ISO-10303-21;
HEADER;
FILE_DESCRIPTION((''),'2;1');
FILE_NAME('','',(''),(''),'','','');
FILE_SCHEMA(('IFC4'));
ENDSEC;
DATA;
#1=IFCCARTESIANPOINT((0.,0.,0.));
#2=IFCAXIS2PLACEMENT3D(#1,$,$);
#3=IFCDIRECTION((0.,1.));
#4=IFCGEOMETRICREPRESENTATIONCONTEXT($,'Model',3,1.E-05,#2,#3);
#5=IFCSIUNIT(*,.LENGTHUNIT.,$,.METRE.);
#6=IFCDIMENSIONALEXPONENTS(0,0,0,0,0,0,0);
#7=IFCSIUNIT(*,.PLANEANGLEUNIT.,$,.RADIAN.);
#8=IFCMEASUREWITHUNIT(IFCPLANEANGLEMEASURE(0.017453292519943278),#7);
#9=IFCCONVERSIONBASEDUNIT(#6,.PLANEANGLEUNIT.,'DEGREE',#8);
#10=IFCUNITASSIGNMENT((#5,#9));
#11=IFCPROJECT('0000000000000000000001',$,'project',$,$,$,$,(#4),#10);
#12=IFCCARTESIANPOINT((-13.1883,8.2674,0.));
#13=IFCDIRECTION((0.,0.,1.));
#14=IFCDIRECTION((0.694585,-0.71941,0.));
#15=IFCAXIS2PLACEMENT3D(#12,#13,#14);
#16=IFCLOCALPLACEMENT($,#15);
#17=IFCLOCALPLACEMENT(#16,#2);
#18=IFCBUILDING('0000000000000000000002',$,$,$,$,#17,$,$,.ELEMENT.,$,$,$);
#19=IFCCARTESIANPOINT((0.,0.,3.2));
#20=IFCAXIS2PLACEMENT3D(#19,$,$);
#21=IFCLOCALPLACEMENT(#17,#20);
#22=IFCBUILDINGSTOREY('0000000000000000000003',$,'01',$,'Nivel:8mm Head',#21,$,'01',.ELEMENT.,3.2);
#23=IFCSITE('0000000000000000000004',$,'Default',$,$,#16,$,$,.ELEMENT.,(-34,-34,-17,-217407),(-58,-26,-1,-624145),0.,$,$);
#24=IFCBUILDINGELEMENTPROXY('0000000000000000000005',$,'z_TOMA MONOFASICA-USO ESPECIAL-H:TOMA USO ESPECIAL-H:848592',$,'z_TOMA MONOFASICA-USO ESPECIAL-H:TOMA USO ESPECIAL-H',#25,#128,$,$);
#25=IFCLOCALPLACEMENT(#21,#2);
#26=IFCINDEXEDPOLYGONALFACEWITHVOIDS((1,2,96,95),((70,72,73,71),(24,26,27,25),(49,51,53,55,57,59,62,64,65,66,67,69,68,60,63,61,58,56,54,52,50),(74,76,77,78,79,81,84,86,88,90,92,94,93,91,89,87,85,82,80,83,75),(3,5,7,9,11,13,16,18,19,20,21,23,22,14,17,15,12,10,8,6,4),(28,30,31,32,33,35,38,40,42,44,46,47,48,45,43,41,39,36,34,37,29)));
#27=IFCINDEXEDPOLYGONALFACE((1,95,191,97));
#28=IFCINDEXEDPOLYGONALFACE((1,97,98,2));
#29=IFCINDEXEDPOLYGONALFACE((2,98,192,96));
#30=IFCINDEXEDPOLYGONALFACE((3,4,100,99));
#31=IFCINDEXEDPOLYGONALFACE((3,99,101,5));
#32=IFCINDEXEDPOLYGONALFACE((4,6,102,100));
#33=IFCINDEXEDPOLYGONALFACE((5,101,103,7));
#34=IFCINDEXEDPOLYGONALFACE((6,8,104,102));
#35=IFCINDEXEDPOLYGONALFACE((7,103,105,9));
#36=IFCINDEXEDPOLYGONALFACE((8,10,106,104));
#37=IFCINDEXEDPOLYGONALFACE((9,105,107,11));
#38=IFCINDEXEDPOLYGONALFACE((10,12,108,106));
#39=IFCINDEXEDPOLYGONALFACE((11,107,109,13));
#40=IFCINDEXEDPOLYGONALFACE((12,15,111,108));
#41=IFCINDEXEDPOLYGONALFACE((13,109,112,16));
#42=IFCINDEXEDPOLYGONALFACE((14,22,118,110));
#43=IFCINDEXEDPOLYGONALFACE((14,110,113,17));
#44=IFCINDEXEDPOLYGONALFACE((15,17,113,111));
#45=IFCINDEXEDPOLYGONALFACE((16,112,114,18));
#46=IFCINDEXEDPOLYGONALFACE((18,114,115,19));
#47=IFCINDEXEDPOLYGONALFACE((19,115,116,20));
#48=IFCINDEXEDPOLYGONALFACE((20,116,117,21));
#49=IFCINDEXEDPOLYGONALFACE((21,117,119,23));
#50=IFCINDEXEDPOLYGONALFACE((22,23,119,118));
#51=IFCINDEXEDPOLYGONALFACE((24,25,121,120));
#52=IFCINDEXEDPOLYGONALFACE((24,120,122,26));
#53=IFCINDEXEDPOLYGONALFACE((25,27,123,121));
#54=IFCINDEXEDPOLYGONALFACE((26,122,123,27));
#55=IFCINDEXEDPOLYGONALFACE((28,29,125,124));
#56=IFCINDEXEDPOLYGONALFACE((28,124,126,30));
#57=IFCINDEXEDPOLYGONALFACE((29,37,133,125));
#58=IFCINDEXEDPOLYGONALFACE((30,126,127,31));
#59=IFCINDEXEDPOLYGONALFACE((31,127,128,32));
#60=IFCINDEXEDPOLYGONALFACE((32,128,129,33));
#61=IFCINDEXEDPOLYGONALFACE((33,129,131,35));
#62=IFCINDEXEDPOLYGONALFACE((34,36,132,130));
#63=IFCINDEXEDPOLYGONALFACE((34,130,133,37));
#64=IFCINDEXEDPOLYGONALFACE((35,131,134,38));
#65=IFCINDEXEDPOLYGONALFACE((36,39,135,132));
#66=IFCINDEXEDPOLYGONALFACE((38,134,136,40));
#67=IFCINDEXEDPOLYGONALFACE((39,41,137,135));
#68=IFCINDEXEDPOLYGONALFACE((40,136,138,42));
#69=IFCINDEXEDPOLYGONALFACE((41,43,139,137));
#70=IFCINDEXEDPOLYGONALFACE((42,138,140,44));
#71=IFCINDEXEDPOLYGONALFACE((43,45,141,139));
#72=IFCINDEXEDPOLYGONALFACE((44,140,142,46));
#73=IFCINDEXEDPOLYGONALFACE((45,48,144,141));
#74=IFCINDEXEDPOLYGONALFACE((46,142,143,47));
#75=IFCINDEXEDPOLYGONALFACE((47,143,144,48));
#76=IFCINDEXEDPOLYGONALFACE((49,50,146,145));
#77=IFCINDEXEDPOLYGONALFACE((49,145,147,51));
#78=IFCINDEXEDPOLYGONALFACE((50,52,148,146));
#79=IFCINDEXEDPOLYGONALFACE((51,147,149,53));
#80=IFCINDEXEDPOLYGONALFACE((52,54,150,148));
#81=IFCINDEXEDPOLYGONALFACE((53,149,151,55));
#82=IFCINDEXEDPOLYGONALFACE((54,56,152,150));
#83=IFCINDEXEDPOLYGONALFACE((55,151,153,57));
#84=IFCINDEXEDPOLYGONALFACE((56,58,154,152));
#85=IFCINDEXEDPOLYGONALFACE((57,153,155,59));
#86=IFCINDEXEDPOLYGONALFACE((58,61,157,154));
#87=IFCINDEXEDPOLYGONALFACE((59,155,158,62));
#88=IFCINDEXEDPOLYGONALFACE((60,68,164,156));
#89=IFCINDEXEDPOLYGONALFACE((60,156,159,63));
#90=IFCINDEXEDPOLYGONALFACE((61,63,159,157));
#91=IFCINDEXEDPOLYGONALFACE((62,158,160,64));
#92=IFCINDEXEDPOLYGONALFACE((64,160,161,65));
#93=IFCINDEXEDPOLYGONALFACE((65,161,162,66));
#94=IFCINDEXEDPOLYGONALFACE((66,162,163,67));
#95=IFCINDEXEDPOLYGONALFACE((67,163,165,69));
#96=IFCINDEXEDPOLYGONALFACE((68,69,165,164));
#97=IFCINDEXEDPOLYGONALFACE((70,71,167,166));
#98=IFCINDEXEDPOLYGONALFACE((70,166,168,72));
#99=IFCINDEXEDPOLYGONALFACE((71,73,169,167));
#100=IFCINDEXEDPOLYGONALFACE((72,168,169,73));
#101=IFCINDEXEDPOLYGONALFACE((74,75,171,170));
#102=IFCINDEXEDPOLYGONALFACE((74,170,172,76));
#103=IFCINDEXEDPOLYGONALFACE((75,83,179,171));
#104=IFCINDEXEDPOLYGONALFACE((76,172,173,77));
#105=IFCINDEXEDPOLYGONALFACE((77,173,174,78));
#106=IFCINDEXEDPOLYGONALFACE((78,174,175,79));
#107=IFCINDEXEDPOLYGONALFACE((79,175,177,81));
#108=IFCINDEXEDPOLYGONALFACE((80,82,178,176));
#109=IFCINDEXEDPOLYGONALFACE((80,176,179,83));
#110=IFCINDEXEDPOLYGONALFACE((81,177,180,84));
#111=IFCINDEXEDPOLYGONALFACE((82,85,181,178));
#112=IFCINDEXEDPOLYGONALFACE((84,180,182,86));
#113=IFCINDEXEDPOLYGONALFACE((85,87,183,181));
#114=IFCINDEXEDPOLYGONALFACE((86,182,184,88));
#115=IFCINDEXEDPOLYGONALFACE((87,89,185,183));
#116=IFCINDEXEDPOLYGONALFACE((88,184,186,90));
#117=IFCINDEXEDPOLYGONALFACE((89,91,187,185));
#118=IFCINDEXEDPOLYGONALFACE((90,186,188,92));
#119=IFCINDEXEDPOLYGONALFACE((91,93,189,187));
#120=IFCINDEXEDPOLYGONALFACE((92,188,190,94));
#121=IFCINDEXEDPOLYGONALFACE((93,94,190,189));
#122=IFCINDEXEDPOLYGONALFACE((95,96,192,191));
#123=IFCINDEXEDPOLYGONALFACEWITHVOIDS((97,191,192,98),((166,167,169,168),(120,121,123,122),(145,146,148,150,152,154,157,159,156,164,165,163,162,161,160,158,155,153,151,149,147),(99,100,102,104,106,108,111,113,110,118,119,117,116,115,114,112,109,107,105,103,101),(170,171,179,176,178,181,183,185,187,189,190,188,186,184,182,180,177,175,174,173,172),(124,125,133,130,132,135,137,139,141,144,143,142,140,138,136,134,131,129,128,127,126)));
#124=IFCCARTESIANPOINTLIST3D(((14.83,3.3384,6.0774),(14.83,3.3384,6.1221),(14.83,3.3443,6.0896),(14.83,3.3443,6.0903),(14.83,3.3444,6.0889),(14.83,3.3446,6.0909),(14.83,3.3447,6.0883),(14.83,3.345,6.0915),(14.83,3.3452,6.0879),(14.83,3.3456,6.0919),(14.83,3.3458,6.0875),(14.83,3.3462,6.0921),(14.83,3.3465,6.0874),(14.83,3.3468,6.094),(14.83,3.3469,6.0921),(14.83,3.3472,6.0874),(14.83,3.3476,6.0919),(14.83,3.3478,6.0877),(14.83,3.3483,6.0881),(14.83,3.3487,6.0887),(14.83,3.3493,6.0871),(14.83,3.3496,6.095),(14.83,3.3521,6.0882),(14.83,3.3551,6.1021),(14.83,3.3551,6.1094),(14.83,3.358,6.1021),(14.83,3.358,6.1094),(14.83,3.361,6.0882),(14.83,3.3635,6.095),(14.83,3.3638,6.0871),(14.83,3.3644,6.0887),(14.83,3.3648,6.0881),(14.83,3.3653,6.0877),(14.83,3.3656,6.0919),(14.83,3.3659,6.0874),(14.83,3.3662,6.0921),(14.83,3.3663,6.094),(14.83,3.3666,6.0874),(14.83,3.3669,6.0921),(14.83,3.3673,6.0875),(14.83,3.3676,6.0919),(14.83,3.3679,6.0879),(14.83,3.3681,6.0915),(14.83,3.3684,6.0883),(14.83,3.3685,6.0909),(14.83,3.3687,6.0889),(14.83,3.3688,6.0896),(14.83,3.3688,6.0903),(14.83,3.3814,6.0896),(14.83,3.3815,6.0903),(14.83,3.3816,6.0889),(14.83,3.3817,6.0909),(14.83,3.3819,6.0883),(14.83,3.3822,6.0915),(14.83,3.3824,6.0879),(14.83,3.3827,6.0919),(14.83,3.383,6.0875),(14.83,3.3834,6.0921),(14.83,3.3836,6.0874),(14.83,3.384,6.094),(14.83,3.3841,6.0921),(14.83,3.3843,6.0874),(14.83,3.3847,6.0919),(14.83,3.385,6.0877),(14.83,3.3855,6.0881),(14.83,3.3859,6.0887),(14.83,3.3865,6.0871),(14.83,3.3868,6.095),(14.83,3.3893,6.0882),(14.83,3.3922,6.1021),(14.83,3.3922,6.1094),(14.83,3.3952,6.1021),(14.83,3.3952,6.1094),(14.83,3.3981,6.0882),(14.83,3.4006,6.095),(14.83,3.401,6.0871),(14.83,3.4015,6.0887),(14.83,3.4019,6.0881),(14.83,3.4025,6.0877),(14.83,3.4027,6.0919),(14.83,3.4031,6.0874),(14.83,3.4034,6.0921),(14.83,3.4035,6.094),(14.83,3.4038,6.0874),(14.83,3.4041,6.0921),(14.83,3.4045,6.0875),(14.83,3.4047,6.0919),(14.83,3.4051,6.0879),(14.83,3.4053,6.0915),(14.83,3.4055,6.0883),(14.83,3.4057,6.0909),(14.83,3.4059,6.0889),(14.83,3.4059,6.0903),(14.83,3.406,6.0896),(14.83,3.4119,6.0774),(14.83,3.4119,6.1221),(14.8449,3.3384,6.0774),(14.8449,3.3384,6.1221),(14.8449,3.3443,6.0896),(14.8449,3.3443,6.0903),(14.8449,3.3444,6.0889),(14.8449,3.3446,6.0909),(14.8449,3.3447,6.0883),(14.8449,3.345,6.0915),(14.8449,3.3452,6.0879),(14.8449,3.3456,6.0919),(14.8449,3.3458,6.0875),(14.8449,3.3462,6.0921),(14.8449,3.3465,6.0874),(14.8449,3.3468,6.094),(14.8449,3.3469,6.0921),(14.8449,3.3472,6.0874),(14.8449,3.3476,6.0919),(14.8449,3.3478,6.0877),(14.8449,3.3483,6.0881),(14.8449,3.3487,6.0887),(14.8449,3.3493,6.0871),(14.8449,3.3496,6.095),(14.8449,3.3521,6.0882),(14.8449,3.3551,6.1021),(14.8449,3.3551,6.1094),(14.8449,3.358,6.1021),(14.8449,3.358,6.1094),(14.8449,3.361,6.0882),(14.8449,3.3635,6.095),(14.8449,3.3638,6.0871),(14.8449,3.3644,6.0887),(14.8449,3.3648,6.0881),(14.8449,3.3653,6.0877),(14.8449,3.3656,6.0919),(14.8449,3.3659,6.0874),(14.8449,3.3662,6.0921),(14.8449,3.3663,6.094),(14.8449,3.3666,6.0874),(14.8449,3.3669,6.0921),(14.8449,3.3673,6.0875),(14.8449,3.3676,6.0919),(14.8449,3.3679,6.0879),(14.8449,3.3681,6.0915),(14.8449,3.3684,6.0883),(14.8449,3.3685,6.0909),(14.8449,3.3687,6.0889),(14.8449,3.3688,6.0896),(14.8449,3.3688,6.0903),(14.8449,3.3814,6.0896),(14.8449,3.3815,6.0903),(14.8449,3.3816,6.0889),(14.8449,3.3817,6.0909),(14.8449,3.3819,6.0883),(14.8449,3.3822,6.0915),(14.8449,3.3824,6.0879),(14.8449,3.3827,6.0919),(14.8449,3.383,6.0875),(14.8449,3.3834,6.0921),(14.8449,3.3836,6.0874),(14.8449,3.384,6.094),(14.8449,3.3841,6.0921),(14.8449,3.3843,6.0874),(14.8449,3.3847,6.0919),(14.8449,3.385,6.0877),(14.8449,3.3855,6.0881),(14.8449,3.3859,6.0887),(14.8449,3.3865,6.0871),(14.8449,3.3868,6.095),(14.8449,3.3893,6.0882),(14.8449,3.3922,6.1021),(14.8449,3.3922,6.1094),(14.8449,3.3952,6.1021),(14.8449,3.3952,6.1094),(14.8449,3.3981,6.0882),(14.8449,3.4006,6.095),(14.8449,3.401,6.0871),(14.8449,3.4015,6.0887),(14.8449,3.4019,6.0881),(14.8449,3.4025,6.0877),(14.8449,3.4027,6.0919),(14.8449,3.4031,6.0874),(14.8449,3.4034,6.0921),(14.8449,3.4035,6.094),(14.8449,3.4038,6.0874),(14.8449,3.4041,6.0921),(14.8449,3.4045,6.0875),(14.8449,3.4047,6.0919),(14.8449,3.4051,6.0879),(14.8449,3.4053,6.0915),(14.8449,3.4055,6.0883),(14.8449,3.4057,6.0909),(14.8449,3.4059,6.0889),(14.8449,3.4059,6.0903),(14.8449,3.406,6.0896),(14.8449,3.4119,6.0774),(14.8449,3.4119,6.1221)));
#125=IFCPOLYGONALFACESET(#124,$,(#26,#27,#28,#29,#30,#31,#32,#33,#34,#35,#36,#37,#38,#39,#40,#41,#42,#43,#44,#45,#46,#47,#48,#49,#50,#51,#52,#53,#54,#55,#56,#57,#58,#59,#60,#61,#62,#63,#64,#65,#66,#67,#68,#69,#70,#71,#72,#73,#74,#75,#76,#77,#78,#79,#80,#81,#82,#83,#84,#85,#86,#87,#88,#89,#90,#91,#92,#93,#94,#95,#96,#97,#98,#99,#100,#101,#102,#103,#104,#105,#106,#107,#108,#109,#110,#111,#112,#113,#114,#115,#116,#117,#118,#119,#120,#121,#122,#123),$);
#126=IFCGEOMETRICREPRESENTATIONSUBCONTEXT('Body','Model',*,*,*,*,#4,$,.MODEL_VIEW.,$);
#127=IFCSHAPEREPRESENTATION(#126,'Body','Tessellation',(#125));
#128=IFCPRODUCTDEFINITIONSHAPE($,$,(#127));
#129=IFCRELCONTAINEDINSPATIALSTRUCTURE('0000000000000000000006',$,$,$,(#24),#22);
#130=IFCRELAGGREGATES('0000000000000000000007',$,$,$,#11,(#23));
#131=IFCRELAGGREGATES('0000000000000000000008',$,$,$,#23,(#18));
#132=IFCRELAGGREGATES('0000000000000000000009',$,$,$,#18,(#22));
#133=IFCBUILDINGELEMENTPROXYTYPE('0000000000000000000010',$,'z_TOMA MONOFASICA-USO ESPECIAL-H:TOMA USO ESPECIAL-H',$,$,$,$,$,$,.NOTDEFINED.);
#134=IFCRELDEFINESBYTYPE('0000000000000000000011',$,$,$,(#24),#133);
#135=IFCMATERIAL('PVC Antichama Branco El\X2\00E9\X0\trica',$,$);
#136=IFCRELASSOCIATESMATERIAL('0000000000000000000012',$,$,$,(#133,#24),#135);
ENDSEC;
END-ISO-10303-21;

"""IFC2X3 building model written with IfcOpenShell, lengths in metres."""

from ifc_helpers import new_model, entity, si_unit, converted_unit, direction, frame, frame_2d, origin, place, context, subcontext, project, spatial, polyline, circle_curve, parameter, trimmed, segment, composite_curve, outline, extrude, source, transform, mapped, material, type_object, type_shapes, element, save


model = new_model("IFC2X3")

# Units and contexts
model_context = context("Model", 3, precision=1e-05, world=origin(), true_north=direction((0.0, 1.0)))
body_context = subcontext(model_context, "Body", "Model", "MODEL_VIEW")
ifc_project = project(units=[si_unit("LENGTHUNIT", "METRE"), converted_unit("PLANEANGLEUNIT", "DEGREE", entity("IfcPlaneAngleMeasure", 0.017453292519943278), si_unit("PLANEANGLEUNIT", "RADIAN"), dimensions=[0, 0, 0, 0, 0, 0, 0])], contexts=[model_context])

# Site, building, storey
site_placement = place(None, frame((-13.1883, 8.2674, 0.0), z_axis=(0.0, 0.0, 1.0), x_axis=(0.694585, -0.71941, 0.0)))
site = spatial("IfcSite", under=ifc_project, at=site_placement, Name="Default", CompositionType="ELEMENT", RefLatitude=(-34, -34, -17, -217407), RefLongitude=(-58, -26, -1, -624145), RefElevation=0.0)
building_placement = place(site_placement, origin())
building = spatial("IfcBuilding", under=site, at=building_placement, CompositionType="ELEMENT")
storey_placement = place(building_placement, frame((0.0, 0.0, 3.2)))
storey = spatial("IfcBuildingStorey", under=building, at=storey_placement, Name="01", ObjectType="Nivel:8mm Head", LongName="01", CompositionType="ELEMENT", Elevation=3.2)

# Building element proxy
ifc_material_1 = material(Name="PVC Antichama Branco Elétrica")
building_element_proxy_type_1 = type_object("IfcBuildingElementProxyType", Name="z_TOMA MONOFASICA-USO ESPECIAL-H:TOMA USO ESPECIAL-H", PredefinedType="NOTDEFINED", material=ifc_material_1)
shared_shape_1 = source(origin(), body_context, "Body", "SweptSolid", [
    extrude(outline(polyline([(-0.0368, -0.0223), (0.0368, -0.0223), (0.0368, 0.0223), (-0.0368, 0.0223), (-0.0368, -0.0223)]), holes=[composite_curve([segment(polyline([(0.0141, 0.0115), (0.0116, 0.0047)]), True, "CONTINUOUS"), segment(polyline([(0.0116, 0.0047), (0.0088, 0.0057)]), True, "CONTINUOUS"), segment(polyline([(0.0088, 0.0057), (0.0096, 0.0078)]), True, "CONTINUOUS"), segment(trimmed(circle_curve(frame_2d((0.0087, 0.0099), x_axis=(1.0, 0.0)), 0.0024), [parameter(27.118901)], [parameter(292.881099)], True, "PARAMETER"), False, "CONTINUOUS"), segment(polyline([(0.0108, 0.011), (0.0113, 0.0126)]), True, "CONTINUOUS"), segment(polyline([(0.0113, 0.0126), (0.0141, 0.0115)]), True, "CONTINUOUS")], self_intersect=False), composite_curve([segment(polyline([(0.0255, 0.0047), (0.023, 0.0115)]), True, "CONTINUOUS"), segment(polyline([(0.023, 0.0115), (0.0258, 0.0126)]), True, "CONTINUOUS"), segment(polyline([(0.0258, 0.0126), (0.0264, 0.011)]), True, "CONTINUOUS"), segment(trimmed(circle_curve(frame_2d((0.0285, 0.0099), x_axis=(1.0, 0.0)), 0.0024), [parameter(247.118901)], [parameter(152.881099)], True, "PARAMETER"), False, "CONTINUOUS"), segment(polyline([(0.0276, 0.0078), (0.0283, 0.0057)]), True, "CONTINUOUS"), segment(polyline([(0.0283, 0.0057), (0.0255, 0.0047)]), True, "CONTINUOUS")], self_intersect=False), polyline([(0.0201, -0.0024), (0.0201, -0.0097), (0.0171, -0.0097), (0.0171, -0.0024), (0.0201, -0.0024)]), composite_curve([segment(polyline([(-0.0141, 0.0115), (-0.0113, 0.0126)]), True, "CONTINUOUS"), segment(polyline([(-0.0113, 0.0126), (-0.0108, 0.011)]), True, "CONTINUOUS"), segment(trimmed(circle_curve(frame_2d((-0.0087, 0.0099), x_axis=(1.0, 0.0)), 0.0024), [parameter(247.118901)], [parameter(152.881099)], True, "PARAMETER"), False, "CONTINUOUS"), segment(polyline([(-0.0096, 0.0078), (-0.0088, 0.0057)]), True, "CONTINUOUS"), segment(polyline([(-0.0088, 0.0057), (-0.0116, 0.0047)]), True, "CONTINUOUS"), segment(polyline([(-0.0116, 0.0047), (-0.0141, 0.0115)]), True, "CONTINUOUS")], self_intersect=False), composite_curve([segment(polyline([(-0.0255, 0.0047), (-0.0283, 0.0057)]), True, "CONTINUOUS"), segment(polyline([(-0.0283, 0.0057), (-0.0276, 0.0078)]), True, "CONTINUOUS"), segment(trimmed(circle_curve(frame_2d((-0.0285, 0.0099), x_axis=(1.0, 0.0)), 0.0024), [parameter(27.118901)], [parameter(292.881099)], True, "PARAMETER"), False, "CONTINUOUS"), segment(polyline([(-0.0264, 0.011), (-0.0258, 0.0126)]), True, "CONTINUOUS"), segment(polyline([(-0.0258, 0.0126), (-0.023, 0.0115)]), True, "CONTINUOUS"), segment(polyline([(-0.023, 0.0115), (-0.0255, 0.0047)]), True, "CONTINUOUS")], self_intersect=False), polyline([(-0.0201, -0.0024), (-0.0171, -0.0024), (-0.0171, -0.0097), (-0.0201, -0.0097), (-0.0201, -0.0024)])]), frame((0.0, -0.005, 0.0223), z_axis=(0.0, 1.0, 0.0), x_axis=(1.0, 0.0, 0.0)), (0.0, 0.0, 1.0), 0.0148),
])
type_shapes(building_element_proxy_type_1, [shared_shape_1])
proxy_1_placement = place(storey_placement, frame((14.8399, 3.3751, 6.0774), z_axis=(0.0, 0.0, 1.0), x_axis=(0.0, 1.0, 0.0)))
element("IfcBuildingElementProxy", 1, at=proxy_1_placement, inside=storey, type_object=building_element_proxy_type_1, material=ifc_material_1, Name="z_TOMA MONOFASICA-USO ESPECIAL-H:TOMA USO ESPECIAL-H:848592", ObjectType="z_TOMA MONOFASICA-USO ESPECIAL-H:TOMA USO ESPECIAL-H", context=body_context, shape_type="MappedRepresentation", body=[
    mapped(shared_shape_1, transform((0.0, 0.0, 0.0), scale=1.0)),
])

save(model, "model.ifc")
